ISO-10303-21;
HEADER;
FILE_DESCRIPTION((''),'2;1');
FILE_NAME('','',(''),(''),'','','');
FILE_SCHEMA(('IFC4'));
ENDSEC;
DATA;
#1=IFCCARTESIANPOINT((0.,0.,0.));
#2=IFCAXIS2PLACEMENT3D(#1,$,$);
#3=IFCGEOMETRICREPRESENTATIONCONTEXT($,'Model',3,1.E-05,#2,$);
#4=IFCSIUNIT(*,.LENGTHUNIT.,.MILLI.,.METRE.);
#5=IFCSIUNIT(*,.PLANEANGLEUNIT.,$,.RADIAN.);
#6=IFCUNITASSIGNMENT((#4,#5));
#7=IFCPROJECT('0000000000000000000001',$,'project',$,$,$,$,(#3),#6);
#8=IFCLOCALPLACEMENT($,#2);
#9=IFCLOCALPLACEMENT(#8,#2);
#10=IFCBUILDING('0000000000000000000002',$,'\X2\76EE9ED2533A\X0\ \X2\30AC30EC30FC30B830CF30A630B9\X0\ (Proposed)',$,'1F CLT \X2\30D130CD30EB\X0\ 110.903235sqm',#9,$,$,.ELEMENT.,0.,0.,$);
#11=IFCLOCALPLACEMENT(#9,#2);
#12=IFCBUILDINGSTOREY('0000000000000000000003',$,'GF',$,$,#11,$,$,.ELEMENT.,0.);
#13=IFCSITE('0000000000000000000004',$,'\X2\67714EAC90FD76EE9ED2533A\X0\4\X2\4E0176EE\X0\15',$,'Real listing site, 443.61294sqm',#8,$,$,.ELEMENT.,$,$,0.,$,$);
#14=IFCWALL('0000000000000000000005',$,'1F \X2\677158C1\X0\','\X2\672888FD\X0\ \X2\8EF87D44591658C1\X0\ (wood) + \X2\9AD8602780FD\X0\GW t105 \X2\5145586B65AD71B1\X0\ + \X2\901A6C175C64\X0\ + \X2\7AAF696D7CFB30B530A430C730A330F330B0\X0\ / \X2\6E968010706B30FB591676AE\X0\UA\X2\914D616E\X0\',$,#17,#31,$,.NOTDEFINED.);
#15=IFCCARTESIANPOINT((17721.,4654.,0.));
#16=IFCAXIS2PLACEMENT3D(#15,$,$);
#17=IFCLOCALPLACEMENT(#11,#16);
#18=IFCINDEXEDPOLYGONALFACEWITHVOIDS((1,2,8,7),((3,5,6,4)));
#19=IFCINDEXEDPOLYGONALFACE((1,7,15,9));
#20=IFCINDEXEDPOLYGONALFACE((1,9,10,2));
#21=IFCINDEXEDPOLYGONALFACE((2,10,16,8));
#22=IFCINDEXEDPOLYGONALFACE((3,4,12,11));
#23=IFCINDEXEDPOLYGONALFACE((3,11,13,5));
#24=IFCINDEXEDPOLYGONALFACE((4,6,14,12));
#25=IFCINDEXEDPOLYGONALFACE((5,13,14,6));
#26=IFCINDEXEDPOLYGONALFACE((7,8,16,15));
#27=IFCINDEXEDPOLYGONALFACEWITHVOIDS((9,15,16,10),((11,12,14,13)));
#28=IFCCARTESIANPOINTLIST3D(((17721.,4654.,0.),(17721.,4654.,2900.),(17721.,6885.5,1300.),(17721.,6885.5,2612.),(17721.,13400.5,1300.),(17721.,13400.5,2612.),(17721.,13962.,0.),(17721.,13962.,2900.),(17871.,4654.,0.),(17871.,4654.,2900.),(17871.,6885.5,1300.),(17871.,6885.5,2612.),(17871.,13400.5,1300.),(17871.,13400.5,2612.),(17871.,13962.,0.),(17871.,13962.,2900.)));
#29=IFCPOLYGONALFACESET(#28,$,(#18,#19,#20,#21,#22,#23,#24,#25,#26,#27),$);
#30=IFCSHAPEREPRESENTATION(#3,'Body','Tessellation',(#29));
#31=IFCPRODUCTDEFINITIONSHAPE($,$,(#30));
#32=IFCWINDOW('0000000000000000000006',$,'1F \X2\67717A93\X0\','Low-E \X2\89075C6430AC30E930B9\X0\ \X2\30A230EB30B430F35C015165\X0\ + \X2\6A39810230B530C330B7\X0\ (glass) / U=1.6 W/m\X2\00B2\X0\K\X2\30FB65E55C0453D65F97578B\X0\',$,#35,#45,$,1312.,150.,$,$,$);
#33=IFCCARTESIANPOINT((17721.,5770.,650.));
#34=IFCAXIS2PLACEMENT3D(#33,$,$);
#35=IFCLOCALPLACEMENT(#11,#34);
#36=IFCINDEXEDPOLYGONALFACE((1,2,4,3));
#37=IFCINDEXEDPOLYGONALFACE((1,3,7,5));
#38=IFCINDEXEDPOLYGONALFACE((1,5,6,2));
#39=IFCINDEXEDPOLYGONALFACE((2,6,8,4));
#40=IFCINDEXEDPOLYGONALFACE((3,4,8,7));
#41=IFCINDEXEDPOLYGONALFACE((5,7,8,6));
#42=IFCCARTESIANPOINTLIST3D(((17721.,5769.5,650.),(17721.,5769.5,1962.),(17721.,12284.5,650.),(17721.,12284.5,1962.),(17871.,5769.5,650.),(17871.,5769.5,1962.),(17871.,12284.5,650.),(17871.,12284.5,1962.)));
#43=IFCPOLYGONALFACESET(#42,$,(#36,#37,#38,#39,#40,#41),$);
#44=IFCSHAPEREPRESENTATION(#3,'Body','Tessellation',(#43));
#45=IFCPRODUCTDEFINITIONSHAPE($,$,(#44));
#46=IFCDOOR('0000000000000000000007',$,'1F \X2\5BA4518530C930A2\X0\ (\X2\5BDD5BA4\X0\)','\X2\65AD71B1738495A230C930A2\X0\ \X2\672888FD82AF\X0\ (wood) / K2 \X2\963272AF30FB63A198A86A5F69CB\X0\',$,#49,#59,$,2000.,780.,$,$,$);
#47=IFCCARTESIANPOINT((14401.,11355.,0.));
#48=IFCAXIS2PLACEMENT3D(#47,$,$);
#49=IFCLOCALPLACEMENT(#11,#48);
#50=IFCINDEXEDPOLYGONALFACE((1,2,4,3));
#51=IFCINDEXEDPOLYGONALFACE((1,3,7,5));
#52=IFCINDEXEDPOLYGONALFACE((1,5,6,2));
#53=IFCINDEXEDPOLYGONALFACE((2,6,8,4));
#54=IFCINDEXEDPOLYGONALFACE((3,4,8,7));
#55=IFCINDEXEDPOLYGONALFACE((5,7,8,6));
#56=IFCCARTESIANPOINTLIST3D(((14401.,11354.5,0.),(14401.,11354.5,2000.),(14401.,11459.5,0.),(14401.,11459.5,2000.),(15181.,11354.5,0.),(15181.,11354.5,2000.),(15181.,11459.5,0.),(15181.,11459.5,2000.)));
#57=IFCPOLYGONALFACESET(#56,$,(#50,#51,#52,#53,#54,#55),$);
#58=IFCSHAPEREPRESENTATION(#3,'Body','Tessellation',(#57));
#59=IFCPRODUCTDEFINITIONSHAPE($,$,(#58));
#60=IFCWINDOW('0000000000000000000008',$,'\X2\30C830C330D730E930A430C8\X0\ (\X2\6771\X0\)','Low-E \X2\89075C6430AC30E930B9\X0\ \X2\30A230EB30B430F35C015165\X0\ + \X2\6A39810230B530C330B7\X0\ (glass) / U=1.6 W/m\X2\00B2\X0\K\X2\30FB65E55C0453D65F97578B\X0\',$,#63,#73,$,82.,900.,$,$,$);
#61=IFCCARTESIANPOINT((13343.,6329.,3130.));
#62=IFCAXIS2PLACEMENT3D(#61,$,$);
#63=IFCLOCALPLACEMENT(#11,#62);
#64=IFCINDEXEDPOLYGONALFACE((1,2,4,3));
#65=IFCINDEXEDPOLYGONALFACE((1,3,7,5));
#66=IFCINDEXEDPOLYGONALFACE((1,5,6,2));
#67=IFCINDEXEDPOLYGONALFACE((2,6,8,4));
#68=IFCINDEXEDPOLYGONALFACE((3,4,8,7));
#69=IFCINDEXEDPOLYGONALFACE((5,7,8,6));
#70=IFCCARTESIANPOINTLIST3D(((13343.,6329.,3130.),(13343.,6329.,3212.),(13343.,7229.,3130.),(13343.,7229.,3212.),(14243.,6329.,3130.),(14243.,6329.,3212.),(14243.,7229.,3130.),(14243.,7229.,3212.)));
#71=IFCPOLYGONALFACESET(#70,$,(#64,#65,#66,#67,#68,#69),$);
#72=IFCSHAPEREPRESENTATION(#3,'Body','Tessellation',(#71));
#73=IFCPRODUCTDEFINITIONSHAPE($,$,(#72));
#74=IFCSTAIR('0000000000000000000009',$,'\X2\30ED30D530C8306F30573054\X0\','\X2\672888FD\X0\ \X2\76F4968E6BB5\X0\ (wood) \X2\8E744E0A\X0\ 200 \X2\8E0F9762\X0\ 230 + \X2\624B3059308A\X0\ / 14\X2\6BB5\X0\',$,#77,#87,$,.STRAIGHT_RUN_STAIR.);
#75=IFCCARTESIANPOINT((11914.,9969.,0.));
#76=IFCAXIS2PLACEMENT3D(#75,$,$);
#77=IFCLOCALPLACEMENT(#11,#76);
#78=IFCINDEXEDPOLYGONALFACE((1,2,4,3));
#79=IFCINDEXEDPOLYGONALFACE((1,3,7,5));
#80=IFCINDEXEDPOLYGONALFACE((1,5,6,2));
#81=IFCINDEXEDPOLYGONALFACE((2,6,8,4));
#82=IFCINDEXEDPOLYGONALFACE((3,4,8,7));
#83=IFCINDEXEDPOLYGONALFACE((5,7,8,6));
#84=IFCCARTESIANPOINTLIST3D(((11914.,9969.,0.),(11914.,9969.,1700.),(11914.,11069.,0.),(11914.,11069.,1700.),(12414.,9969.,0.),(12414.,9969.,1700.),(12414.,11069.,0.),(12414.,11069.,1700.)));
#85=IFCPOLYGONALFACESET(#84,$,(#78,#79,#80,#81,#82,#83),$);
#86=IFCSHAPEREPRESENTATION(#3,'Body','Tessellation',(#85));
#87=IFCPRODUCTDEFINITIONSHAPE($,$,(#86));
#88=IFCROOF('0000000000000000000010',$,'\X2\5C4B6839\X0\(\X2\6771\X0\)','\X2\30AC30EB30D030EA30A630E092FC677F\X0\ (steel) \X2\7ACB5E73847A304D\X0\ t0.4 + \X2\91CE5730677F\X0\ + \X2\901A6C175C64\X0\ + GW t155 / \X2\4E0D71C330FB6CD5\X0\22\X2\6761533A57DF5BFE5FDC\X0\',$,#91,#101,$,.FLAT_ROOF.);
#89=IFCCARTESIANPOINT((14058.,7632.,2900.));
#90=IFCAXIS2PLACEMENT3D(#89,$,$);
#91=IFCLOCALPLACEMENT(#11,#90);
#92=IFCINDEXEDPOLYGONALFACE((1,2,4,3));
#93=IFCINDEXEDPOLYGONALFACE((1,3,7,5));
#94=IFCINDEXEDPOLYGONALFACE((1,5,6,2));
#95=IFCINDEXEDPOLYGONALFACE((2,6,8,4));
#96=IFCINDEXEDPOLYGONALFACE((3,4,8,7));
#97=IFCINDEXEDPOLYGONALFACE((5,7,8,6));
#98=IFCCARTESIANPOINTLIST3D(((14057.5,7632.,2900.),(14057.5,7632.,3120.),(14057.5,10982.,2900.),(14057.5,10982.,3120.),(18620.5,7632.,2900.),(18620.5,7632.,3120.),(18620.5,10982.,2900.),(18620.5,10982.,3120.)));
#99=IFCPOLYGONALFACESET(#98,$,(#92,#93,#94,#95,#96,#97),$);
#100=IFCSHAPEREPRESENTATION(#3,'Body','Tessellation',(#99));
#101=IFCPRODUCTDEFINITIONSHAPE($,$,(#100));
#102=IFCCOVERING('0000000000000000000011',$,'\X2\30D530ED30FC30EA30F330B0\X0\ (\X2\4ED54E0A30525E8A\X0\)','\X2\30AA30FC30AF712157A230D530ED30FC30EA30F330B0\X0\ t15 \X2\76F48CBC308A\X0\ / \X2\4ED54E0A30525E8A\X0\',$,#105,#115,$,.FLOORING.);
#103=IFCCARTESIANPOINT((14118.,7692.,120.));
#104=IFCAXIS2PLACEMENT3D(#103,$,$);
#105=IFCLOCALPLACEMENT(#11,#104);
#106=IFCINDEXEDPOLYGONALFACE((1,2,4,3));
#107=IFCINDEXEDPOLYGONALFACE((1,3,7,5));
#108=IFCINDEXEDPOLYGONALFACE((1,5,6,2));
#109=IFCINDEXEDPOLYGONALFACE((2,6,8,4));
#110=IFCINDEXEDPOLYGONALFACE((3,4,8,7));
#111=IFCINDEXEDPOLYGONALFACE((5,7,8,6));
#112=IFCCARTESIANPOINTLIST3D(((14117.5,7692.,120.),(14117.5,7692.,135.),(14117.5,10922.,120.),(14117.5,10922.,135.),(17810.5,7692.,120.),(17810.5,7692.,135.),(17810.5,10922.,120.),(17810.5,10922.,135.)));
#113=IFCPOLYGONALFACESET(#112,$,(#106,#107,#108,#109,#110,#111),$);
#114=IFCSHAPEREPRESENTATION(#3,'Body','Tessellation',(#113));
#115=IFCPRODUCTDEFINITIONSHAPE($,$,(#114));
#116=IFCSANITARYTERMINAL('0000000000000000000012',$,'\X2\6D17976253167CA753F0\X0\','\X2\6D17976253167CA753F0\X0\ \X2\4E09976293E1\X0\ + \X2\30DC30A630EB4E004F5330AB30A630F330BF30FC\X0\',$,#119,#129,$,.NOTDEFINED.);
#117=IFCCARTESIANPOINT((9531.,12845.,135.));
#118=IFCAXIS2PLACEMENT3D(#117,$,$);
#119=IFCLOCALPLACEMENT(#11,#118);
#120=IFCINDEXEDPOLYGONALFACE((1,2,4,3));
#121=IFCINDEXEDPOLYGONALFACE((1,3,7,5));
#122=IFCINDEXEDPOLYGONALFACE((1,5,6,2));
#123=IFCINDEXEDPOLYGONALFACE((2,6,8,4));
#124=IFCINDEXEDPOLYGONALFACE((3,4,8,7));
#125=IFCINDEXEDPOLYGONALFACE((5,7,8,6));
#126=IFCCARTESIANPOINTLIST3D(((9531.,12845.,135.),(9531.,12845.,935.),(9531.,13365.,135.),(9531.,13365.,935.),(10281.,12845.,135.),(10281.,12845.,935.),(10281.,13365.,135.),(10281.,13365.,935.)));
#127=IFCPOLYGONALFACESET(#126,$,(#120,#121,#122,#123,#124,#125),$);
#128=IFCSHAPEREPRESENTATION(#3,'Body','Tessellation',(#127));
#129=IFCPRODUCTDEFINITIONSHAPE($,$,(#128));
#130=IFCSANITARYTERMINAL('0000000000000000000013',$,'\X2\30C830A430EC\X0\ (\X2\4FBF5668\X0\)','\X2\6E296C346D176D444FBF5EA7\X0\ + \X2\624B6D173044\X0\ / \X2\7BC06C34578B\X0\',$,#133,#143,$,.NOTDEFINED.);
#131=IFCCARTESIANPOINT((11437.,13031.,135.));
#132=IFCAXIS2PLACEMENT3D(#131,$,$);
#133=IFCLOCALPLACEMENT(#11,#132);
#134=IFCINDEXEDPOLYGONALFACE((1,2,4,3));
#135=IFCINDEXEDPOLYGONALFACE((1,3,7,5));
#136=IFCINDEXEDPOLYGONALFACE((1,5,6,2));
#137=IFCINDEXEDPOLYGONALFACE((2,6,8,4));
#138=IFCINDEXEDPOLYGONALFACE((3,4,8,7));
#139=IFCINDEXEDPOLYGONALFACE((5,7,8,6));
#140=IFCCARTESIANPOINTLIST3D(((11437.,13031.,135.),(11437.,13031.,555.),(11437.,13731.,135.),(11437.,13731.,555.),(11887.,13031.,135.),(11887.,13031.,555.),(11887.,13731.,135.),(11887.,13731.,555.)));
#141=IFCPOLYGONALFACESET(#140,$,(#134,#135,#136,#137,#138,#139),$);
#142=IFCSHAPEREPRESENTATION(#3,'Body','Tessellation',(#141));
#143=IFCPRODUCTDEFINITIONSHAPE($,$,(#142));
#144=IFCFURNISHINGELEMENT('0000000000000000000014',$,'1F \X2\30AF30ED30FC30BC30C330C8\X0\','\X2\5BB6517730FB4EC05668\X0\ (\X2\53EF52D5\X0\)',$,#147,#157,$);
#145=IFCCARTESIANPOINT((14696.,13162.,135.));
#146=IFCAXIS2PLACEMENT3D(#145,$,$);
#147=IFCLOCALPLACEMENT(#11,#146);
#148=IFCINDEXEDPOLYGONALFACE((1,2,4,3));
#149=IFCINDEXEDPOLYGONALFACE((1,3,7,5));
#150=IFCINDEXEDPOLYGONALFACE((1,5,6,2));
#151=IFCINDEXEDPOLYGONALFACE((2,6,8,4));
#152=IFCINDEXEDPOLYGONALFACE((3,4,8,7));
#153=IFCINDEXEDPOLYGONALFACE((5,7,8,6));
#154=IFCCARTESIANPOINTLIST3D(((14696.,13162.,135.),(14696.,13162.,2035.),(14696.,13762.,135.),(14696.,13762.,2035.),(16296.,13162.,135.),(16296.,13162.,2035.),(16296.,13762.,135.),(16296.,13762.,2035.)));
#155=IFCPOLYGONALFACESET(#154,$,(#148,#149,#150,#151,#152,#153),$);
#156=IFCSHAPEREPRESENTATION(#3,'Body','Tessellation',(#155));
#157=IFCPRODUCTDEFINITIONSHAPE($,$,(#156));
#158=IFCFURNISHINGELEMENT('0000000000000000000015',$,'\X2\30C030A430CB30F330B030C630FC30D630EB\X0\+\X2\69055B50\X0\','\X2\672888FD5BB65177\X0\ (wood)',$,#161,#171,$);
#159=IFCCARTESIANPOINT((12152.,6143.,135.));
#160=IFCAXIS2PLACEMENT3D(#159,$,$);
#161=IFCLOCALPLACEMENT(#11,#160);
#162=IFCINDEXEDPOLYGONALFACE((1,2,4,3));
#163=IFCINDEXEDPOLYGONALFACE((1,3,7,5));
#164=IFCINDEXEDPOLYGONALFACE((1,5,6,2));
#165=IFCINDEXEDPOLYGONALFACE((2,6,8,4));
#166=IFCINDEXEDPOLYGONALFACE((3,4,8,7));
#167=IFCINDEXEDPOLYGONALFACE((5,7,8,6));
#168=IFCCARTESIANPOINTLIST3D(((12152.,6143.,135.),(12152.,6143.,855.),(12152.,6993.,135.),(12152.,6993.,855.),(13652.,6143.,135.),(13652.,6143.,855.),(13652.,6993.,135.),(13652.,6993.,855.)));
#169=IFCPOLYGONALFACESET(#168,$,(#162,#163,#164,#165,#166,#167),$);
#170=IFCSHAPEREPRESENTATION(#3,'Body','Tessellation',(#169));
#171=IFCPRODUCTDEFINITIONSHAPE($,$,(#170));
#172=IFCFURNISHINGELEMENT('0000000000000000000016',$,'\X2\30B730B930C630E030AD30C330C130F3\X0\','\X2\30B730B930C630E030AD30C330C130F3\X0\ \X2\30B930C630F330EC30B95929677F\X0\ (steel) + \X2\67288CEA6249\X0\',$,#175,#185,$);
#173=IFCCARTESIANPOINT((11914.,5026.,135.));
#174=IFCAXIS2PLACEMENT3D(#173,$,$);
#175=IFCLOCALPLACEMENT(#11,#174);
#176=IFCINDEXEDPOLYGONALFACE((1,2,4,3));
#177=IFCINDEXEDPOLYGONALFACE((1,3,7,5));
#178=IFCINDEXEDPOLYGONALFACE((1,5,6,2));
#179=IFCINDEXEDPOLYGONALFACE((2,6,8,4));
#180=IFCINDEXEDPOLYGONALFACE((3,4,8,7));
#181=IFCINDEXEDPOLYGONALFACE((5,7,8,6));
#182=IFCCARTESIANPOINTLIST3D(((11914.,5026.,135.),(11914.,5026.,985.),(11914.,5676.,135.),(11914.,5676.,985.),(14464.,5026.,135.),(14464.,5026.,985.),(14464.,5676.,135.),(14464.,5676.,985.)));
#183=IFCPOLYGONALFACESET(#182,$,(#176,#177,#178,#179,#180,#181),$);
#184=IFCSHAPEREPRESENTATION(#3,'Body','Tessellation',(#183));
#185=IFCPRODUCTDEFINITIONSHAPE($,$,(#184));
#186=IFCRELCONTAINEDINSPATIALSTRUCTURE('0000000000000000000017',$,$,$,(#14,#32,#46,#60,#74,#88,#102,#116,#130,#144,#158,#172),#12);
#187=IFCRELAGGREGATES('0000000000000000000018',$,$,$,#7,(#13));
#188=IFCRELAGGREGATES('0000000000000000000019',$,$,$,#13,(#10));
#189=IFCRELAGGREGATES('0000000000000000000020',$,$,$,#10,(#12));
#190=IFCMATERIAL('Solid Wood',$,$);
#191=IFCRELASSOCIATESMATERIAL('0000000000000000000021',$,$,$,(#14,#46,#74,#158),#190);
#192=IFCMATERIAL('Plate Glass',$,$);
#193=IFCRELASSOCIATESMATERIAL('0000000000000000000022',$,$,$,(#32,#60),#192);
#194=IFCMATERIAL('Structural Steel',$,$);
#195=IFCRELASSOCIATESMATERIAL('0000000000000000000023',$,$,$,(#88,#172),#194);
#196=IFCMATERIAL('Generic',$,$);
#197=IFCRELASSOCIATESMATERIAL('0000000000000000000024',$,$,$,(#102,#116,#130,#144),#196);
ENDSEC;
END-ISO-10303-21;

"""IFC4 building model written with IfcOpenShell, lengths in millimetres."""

from ifc_helpers import new_model, si_unit, frame, frame_2d, origin, place, context, project, spatial, rectangle, extrude, material, element, fill, save


model = new_model("IFC4")

# Units and contexts
model_context = context("Model", 3, precision=1e-05, world=origin())
ifc_project = project(units=[si_unit("LENGTHUNIT", "METRE", prefix="MILLI"), si_unit("PLANEANGLEUNIT", "RADIAN")], contexts=[model_context])

# Site, building, storey
site_placement = place(None, origin())
site = spatial("IfcSite", under=ifc_project, at=site_placement, Name="東京都目黒区4丁目15", ObjectType="Real listing site, 443.61294sqm", CompositionType="ELEMENT", RefElevation=0.0)
building_placement = place(site_placement, origin())
building = spatial("IfcBuilding", under=site, at=building_placement, Name="目黒区 ガレージハウス (Proposed)", ObjectType="1F CLT パネル 110.903235sqm", CompositionType="ELEMENT", ElevationOfRefHeight=0.0, ElevationOfTerrain=0.0)
storey_placement = place(building_placement, origin())
storey = spatial("IfcBuildingStorey", under=building, at=storey_placement, Name="GF", CompositionType="ELEMENT", Elevation=0.0)

# Shared definitions
ifc_material_1 = material(Name="Solid Wood")

# Wall, opening, window
wall_1_placement = place(storey_placement, frame((17721.0, 4654.0, 0.0)))
wall_1 = element("IfcWall", 1, at=wall_1_placement, inside=storey, material=ifc_material_1, Name="1F 東壁", Description="木製 軸組外壁 (wood) + 高性能GW t105 充填断熱 + 通気層 + 窯業系サイディング / 準耐火・外皮UA配慮", PredefinedType="NOTDEFINED", context=model_context, shape_type="SweptSolid", body=[
    extrude(rectangle(XDim=150.0, YDim=9308.0, at=frame_2d((75.0, 4654.0))), frame((17721.0, 4654.0, 0.0)), (0.0, 0.0, 1.0), 2900.0),
])
opening_1_placement = place(storey_placement, frame((17721.0, 5770.0, 650.0)))
opening_1 = element("IfcOpeningElement", 2, at=opening_1_placement, cuts=wall_1, PredefinedType="NOTDEFINED", context=model_context, shape_type="SweptSolid", body=[
    extrude(rectangle(XDim=150.0, YDim=6515.0, at=frame_2d((75.0, 3257.0))), frame((17721.0, 5770.0, 650.0)), (0.0, 0.0, 1.0), 1312.0),
])
ifc_material_2 = material(Name="Plate Glass")
window_1_placement = place(storey_placement, frame((17721.0, 5770.0, 650.0)))
window_1 = element("IfcWindow", 3, at=window_1_placement, inside=storey, material=ifc_material_2, Name="1F 東窓", Description="Low-E 複層ガラス アルゴン封入 + 樹脂サッシ (glass) / U=1.6 W/m²K・日射取得型", OverallHeight=1312.0, OverallWidth=150.0, context=model_context, shape_type="SweptSolid", body=[
    extrude(rectangle(XDim=150.0, YDim=6515.0, at=frame_2d((75.0, 3257.0))), frame((17721.0, 5770.0, 650.0)), (0.0, 0.0, 1.0), 1312.0),
])
fill(opening_1, window_1)

# Door
door_placement = place(storey_placement, frame((14401.0, 11355.0, 0.0)))
element("IfcDoor", 4, at=door_placement, inside=storey, material=ifc_material_1, Name="1F 室内ドア (寝室)", Description="断熱玄関ドア 木製芯 (wood) / K2 防犯・採風機構", OverallHeight=2000.0, OverallWidth=780.0, context=model_context, shape_type="SweptSolid", body=[
    extrude(rectangle(XDim=780.0, YDim=105.0, at=frame_2d((390.0, 52.0))), frame((14401.0, 11355.0, 0.0)), (0.0, 0.0, 1.0), 2000.0),
])

# Window
window_2_placement = place(storey_placement, frame((13343.0, 6329.0, 3130.0)))
element("IfcWindow", 5, at=window_2_placement, inside=storey, material=ifc_material_2, Name="トップライト (東)", Description="Low-E 複層ガラス アルゴン封入 + 樹脂サッシ (glass) / U=1.6 W/m²K・日射取得型", OverallHeight=82.0, OverallWidth=900.0, context=model_context, shape_type="SweptSolid", body=[
    extrude(rectangle(XDim=900.0, YDim=900.0, at=frame_2d((450.0, 450.0))), frame((13343.0, 6329.0, 3130.0)), (0.0, 0.0, 1.0), 82.0),
])

# Stair
stair_placement = place(storey_placement, frame((11914.0, 9969.0, 0.0)))
element("IfcStair", 6, at=stair_placement, inside=storey, material=ifc_material_1, Name="ロフトはしご", Description="木製 直階段 (wood) 蹴上 200 踏面 230 + 手すり / 14段", PredefinedType="STRAIGHT_RUN_STAIR", context=model_context, shape_type="SweptSolid", body=[
    extrude(rectangle(XDim=500.0, YDim=1100.0, at=frame_2d((250.0, 550.0))), frame((11914.0, 9969.0, 0.0)), (0.0, 0.0, 1.0), 1700.0),
])

# Roof
ifc_material_3 = material(Name="Structural Steel")
roof_placement = place(storey_placement, frame((14058.0, 7632.0, 2900.0)))
element("IfcRoof", 7, at=roof_placement, inside=storey, material=ifc_material_3, Name="屋根(東)", Description="ガルバリウム鋼板 (steel) 立平葺き t0.4 + 野地板 + 通気層 + GW t155 / 不燃・法22条区域対応", PredefinedType="FLAT_ROOF", context=model_context, shape_type="SweptSolid", body=[
    extrude(rectangle(XDim=4563.0, YDim=3350.0, at=frame_2d((2281.0, 1675.0))), frame((14058.0, 7632.0, 2900.0)), (0.0, 0.0, 1.0), 220.0),
])

# Covering
ifc_material_4 = material(Name="Generic")
covering_placement = place(storey_placement, frame((14118.0, 7692.0, 120.0)))
element("IfcCovering", 8, at=covering_placement, inside=storey, material=ifc_material_4, Name="フローリング (仕上げ床)", Description="オーク無垢フローリング t15 直貼り / 仕上げ床", PredefinedType="FLOORING", context=model_context, shape_type="SweptSolid", body=[
    extrude(rectangle(XDim=3693.0, YDim=3230.0, at=frame_2d((1846.0, 1615.0))), frame((14118.0, 7692.0, 120.0)), (0.0, 0.0, 1.0), 15.0),
])

# Sanitary terminals
sanitary_terminal_1_placement = place(storey_placement, frame((9531.0, 12845.0, 135.0)))
element("IfcSanitaryTerminal", 9, at=sanitary_terminal_1_placement, inside=storey, material=ifc_material_4, Name="洗面化粧台", Description="洗面化粧台 三面鏡 + ボウル一体カウンター", PredefinedType="NOTDEFINED", context=model_context, shape_type="SweptSolid", body=[
    extrude(rectangle(XDim=750.0, YDim=520.0, at=frame_2d((375.0, 260.0))), frame((9531.0, 12845.0, 135.0)), (0.0, 0.0, 1.0), 800.0),
])
sanitary_terminal_2_placement = place(storey_placement, frame((11437.0, 13031.0, 135.0)))
element("IfcSanitaryTerminal", 10, at=sanitary_terminal_2_placement, inside=storey, material=ifc_material_4, Name="トイレ (便器)", Description="温水洗浄便座 + 手洗い / 節水型", PredefinedType="NOTDEFINED", context=model_context, shape_type="SweptSolid", body=[
    extrude(rectangle(XDim=450.0, YDim=700.0, at=frame_2d((225.0, 350.0))), frame((11437.0, 13031.0, 135.0)), (0.0, 0.0, 1.0), 420.0),
])

# Furnishing elements
furnishing_1_placement = place(storey_placement, frame((14696.0, 13162.0, 135.0)))
element("IfcFurnishingElement", 11, at=furnishing_1_placement, inside=storey, material=ifc_material_4, Name="1F クローゼット", Description="家具・什器 (可動)", context=model_context, shape_type="SweptSolid", body=[
    extrude(rectangle(XDim=1600.0, YDim=600.0, at=frame_2d((800.0, 300.0))), frame((14696.0, 13162.0, 135.0)), (0.0, 0.0, 1.0), 1900.0),
])
furnishing_2_placement = place(storey_placement, frame((12152.0, 6143.0, 135.0)))
element("IfcFurnishingElement", 12, at=furnishing_2_placement, inside=storey, material=ifc_material_1, Name="ダイニングテーブル+椅子", Description="木製家具 (wood)", context=model_context, shape_type="SweptSolid", body=[
    extrude(rectangle(XDim=1500.0, YDim=850.0, at=frame_2d((750.0, 425.0))), frame((12152.0, 6143.0, 135.0)), (0.0, 0.0, 1.0), 720.0),
])
furnishing_3_placement = place(storey_placement, frame((11914.0, 5026.0, 135.0)))
element("IfcFurnishingElement", 13, at=furnishing_3_placement, inside=storey, material=ifc_material_3, Name="システムキッチン", Description="システムキッチン ステンレス天板 (steel) + 木質扉", context=model_context, shape_type="SweptSolid", body=[
    extrude(rectangle(XDim=2550.0, YDim=650.0, at=frame_2d((1275.0, 325.0))), frame((11914.0, 5026.0, 135.0)), (0.0, 0.0, 1.0), 850.0),
])

save(model, "model.ifc")
